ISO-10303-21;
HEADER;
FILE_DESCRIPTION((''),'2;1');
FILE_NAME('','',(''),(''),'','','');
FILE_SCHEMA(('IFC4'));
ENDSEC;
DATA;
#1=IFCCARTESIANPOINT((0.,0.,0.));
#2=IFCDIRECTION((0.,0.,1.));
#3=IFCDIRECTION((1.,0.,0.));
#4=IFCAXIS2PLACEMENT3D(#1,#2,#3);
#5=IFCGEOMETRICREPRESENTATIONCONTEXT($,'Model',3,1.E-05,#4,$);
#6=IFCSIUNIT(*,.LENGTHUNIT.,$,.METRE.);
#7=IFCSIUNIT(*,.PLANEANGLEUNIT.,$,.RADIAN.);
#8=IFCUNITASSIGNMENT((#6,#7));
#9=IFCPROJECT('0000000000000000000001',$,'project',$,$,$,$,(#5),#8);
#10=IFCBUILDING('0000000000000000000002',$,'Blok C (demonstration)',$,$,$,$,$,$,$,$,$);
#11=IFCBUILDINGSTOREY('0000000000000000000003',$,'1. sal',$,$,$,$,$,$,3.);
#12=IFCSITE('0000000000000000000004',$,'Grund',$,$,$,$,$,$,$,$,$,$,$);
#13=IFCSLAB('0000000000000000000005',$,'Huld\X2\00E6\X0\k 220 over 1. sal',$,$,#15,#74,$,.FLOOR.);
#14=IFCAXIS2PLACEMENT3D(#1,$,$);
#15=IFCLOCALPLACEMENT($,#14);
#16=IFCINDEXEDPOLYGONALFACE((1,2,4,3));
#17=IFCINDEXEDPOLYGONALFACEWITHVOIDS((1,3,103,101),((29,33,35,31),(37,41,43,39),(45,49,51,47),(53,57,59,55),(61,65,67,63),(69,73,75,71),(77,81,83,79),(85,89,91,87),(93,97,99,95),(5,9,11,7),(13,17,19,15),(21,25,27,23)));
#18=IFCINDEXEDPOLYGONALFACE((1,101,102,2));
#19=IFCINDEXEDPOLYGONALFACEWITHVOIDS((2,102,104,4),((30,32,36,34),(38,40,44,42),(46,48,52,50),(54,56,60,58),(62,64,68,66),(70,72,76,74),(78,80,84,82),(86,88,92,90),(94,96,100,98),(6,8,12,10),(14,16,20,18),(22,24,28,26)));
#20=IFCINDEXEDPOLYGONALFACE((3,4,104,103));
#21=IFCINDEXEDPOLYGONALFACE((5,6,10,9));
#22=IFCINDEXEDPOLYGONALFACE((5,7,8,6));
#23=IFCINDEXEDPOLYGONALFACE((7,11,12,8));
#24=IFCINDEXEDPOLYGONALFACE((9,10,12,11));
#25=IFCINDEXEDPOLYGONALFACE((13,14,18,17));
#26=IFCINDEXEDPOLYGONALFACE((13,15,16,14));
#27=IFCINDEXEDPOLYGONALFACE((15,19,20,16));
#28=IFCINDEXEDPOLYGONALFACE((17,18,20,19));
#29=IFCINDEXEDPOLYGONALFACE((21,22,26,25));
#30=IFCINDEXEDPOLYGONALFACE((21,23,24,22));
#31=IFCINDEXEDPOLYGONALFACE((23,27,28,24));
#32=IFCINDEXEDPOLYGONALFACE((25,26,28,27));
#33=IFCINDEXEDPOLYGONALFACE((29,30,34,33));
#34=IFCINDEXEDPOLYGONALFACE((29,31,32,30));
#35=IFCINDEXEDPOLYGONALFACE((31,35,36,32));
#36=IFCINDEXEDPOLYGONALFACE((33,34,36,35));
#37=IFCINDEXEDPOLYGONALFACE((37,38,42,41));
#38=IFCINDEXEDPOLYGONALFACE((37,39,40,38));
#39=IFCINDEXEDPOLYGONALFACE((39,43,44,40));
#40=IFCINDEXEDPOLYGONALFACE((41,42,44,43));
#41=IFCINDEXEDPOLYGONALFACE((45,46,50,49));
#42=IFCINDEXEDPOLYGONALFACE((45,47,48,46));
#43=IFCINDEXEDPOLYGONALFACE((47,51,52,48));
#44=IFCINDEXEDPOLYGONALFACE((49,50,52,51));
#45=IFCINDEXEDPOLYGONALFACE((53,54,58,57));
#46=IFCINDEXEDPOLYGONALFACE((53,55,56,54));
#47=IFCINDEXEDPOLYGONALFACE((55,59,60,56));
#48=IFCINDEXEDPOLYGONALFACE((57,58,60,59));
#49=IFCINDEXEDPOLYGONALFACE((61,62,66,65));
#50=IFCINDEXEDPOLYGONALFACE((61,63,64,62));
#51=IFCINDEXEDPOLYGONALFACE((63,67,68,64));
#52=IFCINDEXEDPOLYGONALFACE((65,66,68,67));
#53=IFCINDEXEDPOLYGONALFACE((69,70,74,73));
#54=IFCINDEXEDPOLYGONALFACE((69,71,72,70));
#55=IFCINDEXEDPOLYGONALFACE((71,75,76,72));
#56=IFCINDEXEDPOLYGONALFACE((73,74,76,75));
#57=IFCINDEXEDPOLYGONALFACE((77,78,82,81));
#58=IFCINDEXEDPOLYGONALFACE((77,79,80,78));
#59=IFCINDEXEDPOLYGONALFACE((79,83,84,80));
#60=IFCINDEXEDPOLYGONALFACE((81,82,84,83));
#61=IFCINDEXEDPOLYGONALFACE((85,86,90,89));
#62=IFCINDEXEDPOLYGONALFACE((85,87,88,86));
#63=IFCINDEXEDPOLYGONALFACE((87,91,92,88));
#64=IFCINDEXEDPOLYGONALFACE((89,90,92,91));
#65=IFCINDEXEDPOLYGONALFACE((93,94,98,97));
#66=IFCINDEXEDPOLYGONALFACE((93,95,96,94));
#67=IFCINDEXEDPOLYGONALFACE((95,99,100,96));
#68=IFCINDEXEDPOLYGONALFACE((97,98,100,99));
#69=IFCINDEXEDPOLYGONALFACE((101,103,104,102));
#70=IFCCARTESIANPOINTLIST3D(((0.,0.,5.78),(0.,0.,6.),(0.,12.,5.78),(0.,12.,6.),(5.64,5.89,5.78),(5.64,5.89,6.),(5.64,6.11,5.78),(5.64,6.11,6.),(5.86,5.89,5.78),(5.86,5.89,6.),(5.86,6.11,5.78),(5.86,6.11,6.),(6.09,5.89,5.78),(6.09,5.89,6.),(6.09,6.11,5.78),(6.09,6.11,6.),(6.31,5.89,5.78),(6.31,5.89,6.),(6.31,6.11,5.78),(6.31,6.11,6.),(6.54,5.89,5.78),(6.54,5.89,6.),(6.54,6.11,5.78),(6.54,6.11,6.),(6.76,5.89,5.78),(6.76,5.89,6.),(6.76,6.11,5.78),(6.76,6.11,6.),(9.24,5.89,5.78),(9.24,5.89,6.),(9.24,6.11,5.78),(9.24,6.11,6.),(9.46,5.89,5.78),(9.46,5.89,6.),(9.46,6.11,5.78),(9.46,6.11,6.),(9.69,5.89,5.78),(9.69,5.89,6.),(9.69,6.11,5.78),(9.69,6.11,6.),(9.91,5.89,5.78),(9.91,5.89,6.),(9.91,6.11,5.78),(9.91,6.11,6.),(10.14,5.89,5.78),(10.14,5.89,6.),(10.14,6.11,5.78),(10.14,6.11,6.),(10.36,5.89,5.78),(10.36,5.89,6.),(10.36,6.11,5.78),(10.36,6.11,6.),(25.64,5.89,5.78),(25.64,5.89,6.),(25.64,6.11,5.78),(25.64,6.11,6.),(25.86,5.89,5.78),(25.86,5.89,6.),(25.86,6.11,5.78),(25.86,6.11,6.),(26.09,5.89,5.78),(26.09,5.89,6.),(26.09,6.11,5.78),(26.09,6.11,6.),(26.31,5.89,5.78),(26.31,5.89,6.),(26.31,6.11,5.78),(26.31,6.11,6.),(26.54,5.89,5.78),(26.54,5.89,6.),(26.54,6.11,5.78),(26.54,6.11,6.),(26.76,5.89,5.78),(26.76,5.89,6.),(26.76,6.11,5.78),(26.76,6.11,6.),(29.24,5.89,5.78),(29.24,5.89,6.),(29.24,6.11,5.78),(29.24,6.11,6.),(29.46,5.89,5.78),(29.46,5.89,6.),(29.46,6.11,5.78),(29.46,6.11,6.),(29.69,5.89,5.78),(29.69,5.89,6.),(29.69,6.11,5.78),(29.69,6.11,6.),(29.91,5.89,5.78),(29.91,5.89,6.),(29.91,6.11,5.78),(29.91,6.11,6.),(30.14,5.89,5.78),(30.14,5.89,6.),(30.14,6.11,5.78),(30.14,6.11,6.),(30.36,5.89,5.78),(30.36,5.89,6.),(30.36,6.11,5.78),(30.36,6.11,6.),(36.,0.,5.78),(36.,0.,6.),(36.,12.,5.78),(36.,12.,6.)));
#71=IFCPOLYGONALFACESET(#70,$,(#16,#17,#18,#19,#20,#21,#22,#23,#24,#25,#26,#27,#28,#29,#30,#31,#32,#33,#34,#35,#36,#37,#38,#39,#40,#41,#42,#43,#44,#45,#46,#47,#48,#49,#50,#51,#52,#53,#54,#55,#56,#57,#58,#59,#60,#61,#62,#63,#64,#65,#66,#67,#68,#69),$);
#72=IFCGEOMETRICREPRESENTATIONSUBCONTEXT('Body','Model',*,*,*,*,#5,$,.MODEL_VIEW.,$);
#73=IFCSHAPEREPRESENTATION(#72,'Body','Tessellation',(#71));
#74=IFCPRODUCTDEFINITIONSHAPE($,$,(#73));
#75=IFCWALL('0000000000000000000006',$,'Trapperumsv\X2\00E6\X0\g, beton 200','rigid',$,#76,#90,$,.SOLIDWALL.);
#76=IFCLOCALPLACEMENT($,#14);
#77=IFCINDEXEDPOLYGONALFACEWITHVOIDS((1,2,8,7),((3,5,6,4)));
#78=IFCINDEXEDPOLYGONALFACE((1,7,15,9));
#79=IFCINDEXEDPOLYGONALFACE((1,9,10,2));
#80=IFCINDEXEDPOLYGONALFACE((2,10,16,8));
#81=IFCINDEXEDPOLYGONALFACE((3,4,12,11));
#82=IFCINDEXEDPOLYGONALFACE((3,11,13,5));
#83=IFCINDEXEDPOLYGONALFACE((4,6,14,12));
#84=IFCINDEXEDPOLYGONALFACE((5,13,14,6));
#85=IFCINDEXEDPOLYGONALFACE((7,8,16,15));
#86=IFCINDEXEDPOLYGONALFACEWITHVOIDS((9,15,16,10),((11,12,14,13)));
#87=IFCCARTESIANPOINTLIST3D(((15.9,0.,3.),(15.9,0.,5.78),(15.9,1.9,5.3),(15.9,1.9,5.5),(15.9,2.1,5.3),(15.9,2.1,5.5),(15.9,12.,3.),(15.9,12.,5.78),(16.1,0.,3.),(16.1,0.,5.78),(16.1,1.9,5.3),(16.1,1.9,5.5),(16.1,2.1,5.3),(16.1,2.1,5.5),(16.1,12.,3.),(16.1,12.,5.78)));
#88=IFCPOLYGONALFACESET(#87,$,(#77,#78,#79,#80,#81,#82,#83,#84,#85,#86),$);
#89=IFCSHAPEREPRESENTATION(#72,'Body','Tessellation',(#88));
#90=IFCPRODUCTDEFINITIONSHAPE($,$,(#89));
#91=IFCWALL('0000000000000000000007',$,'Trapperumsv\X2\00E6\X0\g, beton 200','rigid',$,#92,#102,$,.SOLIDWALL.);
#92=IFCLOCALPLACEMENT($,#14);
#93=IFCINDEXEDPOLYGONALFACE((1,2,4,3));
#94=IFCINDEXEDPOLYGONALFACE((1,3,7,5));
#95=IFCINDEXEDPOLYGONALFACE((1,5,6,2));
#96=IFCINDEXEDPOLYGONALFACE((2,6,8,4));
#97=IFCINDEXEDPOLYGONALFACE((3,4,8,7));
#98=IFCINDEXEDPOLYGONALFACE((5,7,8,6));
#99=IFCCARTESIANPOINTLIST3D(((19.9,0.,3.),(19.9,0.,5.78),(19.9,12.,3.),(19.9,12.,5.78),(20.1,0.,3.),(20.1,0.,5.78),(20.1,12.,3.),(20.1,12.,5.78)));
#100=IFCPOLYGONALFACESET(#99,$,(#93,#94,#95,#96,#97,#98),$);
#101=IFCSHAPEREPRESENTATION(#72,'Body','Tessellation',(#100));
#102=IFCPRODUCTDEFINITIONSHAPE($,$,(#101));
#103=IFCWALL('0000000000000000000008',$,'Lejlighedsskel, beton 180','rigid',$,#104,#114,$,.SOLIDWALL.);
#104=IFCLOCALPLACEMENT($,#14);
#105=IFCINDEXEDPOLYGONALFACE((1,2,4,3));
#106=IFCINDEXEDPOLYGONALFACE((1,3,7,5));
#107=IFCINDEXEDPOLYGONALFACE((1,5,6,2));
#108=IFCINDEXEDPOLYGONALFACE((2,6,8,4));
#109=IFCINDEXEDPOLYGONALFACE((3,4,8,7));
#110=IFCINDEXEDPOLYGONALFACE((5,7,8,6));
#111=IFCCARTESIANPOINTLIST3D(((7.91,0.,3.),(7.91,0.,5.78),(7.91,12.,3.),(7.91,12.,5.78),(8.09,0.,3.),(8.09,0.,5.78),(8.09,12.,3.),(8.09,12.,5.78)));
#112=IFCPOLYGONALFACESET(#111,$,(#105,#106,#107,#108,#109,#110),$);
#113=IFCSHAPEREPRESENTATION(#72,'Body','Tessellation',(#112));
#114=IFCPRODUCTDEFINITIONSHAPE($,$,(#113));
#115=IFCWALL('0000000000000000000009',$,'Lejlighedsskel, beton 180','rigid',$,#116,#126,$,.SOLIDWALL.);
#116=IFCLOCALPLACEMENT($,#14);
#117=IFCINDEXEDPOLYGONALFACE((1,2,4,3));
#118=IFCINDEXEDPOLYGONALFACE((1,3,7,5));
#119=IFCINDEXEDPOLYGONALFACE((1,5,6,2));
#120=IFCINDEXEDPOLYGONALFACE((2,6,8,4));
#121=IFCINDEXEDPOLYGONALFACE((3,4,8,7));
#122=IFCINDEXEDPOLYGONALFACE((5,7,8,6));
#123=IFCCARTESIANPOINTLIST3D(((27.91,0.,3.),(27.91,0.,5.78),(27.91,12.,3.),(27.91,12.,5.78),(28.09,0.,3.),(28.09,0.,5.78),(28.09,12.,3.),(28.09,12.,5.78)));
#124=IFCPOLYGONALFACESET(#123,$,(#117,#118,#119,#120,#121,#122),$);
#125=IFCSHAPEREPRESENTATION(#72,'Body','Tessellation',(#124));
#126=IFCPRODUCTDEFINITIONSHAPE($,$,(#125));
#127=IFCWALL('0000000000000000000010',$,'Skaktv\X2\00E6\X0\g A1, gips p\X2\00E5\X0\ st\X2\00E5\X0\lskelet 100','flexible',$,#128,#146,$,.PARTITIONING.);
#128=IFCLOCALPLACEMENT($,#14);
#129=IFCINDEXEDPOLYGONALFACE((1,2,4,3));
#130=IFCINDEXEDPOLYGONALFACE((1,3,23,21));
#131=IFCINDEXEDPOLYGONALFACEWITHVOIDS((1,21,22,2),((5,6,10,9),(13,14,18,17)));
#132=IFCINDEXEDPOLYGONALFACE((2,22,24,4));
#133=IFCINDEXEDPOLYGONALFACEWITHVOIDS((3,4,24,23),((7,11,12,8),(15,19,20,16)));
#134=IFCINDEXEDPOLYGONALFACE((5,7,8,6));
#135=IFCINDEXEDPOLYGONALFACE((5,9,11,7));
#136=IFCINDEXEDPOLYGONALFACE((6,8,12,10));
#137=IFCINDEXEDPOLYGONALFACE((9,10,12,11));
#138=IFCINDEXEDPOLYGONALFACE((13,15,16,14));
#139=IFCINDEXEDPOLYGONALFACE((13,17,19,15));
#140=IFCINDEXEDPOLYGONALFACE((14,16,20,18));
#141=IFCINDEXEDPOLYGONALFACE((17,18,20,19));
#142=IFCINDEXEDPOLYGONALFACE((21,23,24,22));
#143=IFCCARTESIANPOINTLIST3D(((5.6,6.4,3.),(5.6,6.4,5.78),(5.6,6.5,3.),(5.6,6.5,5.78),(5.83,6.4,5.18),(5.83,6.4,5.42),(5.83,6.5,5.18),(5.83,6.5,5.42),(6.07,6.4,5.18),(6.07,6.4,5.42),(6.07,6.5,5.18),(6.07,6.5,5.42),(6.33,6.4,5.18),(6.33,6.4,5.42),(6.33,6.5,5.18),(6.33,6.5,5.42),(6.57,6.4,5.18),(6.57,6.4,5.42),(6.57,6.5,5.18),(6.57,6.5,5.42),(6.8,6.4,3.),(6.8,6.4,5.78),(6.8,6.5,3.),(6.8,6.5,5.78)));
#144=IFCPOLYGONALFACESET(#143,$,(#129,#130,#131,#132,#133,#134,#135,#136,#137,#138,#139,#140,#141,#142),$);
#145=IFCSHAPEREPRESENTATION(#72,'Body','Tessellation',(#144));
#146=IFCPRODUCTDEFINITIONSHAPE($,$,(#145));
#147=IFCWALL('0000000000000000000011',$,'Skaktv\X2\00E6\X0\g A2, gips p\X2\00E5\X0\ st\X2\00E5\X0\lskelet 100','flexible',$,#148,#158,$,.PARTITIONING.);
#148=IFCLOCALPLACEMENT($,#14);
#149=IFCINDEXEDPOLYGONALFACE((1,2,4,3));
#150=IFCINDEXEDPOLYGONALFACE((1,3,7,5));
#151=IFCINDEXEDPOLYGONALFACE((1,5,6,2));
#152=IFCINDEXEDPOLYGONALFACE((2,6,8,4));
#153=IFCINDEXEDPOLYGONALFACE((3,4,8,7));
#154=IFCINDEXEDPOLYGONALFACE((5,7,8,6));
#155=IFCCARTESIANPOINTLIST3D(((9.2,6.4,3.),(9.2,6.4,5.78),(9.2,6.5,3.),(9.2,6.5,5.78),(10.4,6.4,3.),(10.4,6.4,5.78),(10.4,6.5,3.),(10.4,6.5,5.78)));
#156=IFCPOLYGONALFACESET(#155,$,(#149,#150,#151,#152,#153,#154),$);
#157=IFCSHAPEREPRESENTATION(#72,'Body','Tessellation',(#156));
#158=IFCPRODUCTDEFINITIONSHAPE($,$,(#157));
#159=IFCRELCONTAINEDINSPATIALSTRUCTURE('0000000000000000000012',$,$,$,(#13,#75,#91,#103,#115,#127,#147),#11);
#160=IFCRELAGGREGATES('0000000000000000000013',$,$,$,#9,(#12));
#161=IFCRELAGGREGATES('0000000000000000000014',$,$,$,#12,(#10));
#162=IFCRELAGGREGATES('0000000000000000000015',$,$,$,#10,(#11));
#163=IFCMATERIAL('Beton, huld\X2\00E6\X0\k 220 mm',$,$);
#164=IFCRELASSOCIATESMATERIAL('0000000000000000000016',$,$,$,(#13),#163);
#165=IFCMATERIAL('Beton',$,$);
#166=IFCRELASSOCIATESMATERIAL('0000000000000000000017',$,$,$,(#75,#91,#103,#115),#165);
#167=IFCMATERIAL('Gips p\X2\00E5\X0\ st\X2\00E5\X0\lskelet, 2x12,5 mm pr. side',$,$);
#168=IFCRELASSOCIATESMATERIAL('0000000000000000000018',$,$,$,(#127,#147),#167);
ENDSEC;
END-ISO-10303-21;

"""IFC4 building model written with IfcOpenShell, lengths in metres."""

from ifc_helpers import new_model, si_unit, frame, origin_with_axes, place, context, subcontext, project, spatial, polyline, outline, extrude, material, element, save


model = new_model("IFC4")

# Units and contexts
model_context = context("Model", 3, precision=1e-05, world=origin_with_axes())
body_context = subcontext(model_context, "Body", "Model", "MODEL_VIEW")
ifc_project = project(units=[si_unit("LENGTHUNIT", "METRE"), si_unit("PLANEANGLEUNIT", "RADIAN")], contexts=[model_context])

# Site, building, storey
site = spatial("IfcSite", under=ifc_project, Name="Grund")
building = spatial("IfcBuilding", under=site, Name="Blok C (demonstration)")
storey = spatial("IfcBuildingStorey", under=building, Name="1. sal", Elevation=3.0)

# Slab, openings
ifc_material_1 = material(Name="Beton, huldæk 220 mm")
slab_placement = place(None, origin_with_axes())
slab = element("IfcSlab", 1, at=slab_placement, inside=storey, material=ifc_material_1, Name="Huldæk 220 over 1. sal", PredefinedType="FLOOR", context=body_context, shape_type="SweptSolid", body=[
    extrude(outline(polyline([(0.0, 0.0), (36.0, 0.0), (36.0, 12.0), (0.0, 12.0), (0.0, 0.0)])), frame((0.0, 0.0, 5.78)), (0.0, 0.0, 1.0), 0.22),
])
opening_1_placement = place(slab_placement, origin_with_axes())
element("IfcOpeningElement", 2, at=opening_1_placement, cuts=slab, PredefinedType="OPENING", context=body_context, shape_type="SweptSolid", body=[
    extrude(outline(polyline([(5.64, 5.89), (5.86, 5.89), (5.86, 6.11), (5.64, 6.11), (5.64, 5.89)])), frame((0.0, 0.0, 5.77)), (0.0, 0.0, 1.0), 0.24),
])
opening_2_placement = place(slab_placement, origin_with_axes())
element("IfcOpeningElement", 3, at=opening_2_placement, cuts=slab, PredefinedType="OPENING", context=body_context, shape_type="SweptSolid", body=[
    extrude(outline(polyline([(6.09, 5.89), (6.31, 5.89), (6.31, 6.11), (6.09, 6.11), (6.09, 5.89)])), frame((0.0, 0.0, 5.77)), (0.0, 0.0, 1.0), 0.24),
])
opening_3_placement = place(slab_placement, origin_with_axes())
element("IfcOpeningElement", 4, at=opening_3_placement, cuts=slab, PredefinedType="OPENING", context=body_context, shape_type="SweptSolid", body=[
    extrude(outline(polyline([(6.54, 5.89), (6.76, 5.89), (6.76, 6.11), (6.54, 6.11), (6.54, 5.89)])), frame((0.0, 0.0, 5.77)), (0.0, 0.0, 1.0), 0.24),
])
opening_4_placement = place(slab_placement, origin_with_axes())
element("IfcOpeningElement", 5, at=opening_4_placement, cuts=slab, PredefinedType="OPENING", context=body_context, shape_type="SweptSolid", body=[
    extrude(outline(polyline([(9.24, 5.89), (9.46, 5.89), (9.46, 6.11), (9.24, 6.11), (9.24, 5.89)])), frame((0.0, 0.0, 5.77)), (0.0, 0.0, 1.0), 0.24),
])
opening_5_placement = place(slab_placement, origin_with_axes())
element("IfcOpeningElement", 6, at=opening_5_placement, cuts=slab, PredefinedType="OPENING", context=body_context, shape_type="SweptSolid", body=[
    extrude(outline(polyline([(9.69, 5.89), (9.91, 5.89), (9.91, 6.11), (9.69, 6.11), (9.69, 5.89)])), frame((0.0, 0.0, 5.77)), (0.0, 0.0, 1.0), 0.24),
])
opening_6_placement = place(slab_placement, origin_with_axes())
element("IfcOpeningElement", 7, at=opening_6_placement, cuts=slab, PredefinedType="OPENING", context=body_context, shape_type="SweptSolid", body=[
    extrude(outline(polyline([(10.14, 5.89), (10.36, 5.89), (10.36, 6.11), (10.14, 6.11), (10.14, 5.89)])), frame((0.0, 0.0, 5.77)), (0.0, 0.0, 1.0), 0.24),
])
opening_7_placement = place(slab_placement, origin_with_axes())
element("IfcOpeningElement", 8, at=opening_7_placement, cuts=slab, PredefinedType="OPENING", context=body_context, shape_type="SweptSolid", body=[
    extrude(outline(polyline([(25.64, 5.89), (25.86, 5.89), (25.86, 6.11), (25.64, 6.11), (25.64, 5.89)])), frame((0.0, 0.0, 5.77)), (0.0, 0.0, 1.0), 0.24),
])
opening_8_placement = place(slab_placement, origin_with_axes())
element("IfcOpeningElement", 9, at=opening_8_placement, cuts=slab, PredefinedType="OPENING", context=body_context, shape_type="SweptSolid", body=[
    extrude(outline(polyline([(26.09, 5.89), (26.31, 5.89), (26.31, 6.11), (26.09, 6.11), (26.09, 5.89)])), frame((0.0, 0.0, 5.77)), (0.0, 0.0, 1.0), 0.24),
])
opening_9_placement = place(slab_placement, origin_with_axes())
element("IfcOpeningElement", 10, at=opening_9_placement, cuts=slab, PredefinedType="OPENING", context=body_context, shape_type="SweptSolid", body=[
    extrude(outline(polyline([(26.54, 5.89), (26.76, 5.89), (26.76, 6.11), (26.54, 6.11), (26.54, 5.89)])), frame((0.0, 0.0, 5.77)), (0.0, 0.0, 1.0), 0.24),
])
opening_10_placement = place(slab_placement, origin_with_axes())
element("IfcOpeningElement", 11, at=opening_10_placement, cuts=slab, PredefinedType="OPENING", context=body_context, shape_type="SweptSolid", body=[
    extrude(outline(polyline([(29.24, 5.89), (29.46, 5.89), (29.46, 6.11), (29.24, 6.11), (29.24, 5.89)])), frame((0.0, 0.0, 5.77)), (0.0, 0.0, 1.0), 0.24),
])
opening_11_placement = place(slab_placement, origin_with_axes())
element("IfcOpeningElement", 12, at=opening_11_placement, cuts=slab, PredefinedType="OPENING", context=body_context, shape_type="SweptSolid", body=[
    extrude(outline(polyline([(29.69, 5.89), (29.91, 5.89), (29.91, 6.11), (29.69, 6.11), (29.69, 5.89)])), frame((0.0, 0.0, 5.77)), (0.0, 0.0, 1.0), 0.24),
])
opening_12_placement = place(slab_placement, origin_with_axes())
element("IfcOpeningElement", 13, at=opening_12_placement, cuts=slab, PredefinedType="OPENING", context=body_context, shape_type="SweptSolid", body=[
    extrude(outline(polyline([(30.14, 5.89), (30.36, 5.89), (30.36, 6.11), (30.14, 6.11), (30.14, 5.89)])), frame((0.0, 0.0, 5.77)), (0.0, 0.0, 1.0), 0.24),
])

# Wall, opening
ifc_material_2 = material(Name="Beton")
wall_1_placement = place(None, origin_with_axes())
wall_1 = element("IfcWall", 14, at=wall_1_placement, inside=storey, material=ifc_material_2, Name="Trapperumsvæg, beton 200", Description="rigid", PredefinedType="SOLIDWALL", context=body_context, shape_type="SweptSolid", body=[
    extrude(outline(polyline([(15.9, 0.0), (16.1, 0.0), (16.1, 12.0), (15.9, 12.0), (15.9, 0.0)])), frame((0.0, 0.0, 3.0)), (0.0, 0.0, 1.0), 2.78),
])
opening_13_placement = place(wall_1_placement, origin_with_axes())
element("IfcOpeningElement", 15, at=opening_13_placement, cuts=wall_1, PredefinedType="OPENING", context=body_context, shape_type="SweptSolid", body=[
    extrude(outline(polyline([(15.88, 1.9), (16.12, 1.9), (16.12, 2.1), (15.88, 2.1), (15.88, 1.9)])), frame((0.0, 0.0, 5.3)), (0.0, 0.0, 1.0), 0.2),
])

# Walls
wall_2_placement = place(None, origin_with_axes())
element("IfcWall", 16, at=wall_2_placement, inside=storey, material=ifc_material_2, Name="Trapperumsvæg, beton 200", Description="rigid", PredefinedType="SOLIDWALL", context=body_context, shape_type="SweptSolid", body=[
    extrude(outline(polyline([(19.9, 0.0), (20.1, 0.0), (20.1, 12.0), (19.9, 12.0), (19.9, 0.0)])), frame((0.0, 0.0, 3.0)), (0.0, 0.0, 1.0), 2.78),
])
wall_3_placement = place(None, origin_with_axes())
element("IfcWall", 17, at=wall_3_placement, inside=storey, material=ifc_material_2, Name="Lejlighedsskel, beton 180", Description="rigid", PredefinedType="SOLIDWALL", context=body_context, shape_type="SweptSolid", body=[
    extrude(outline(polyline([(7.91, 0.0), (8.09, 0.0), (8.09, 12.0), (7.91, 12.0), (7.91, 0.0)])), frame((0.0, 0.0, 3.0)), (0.0, 0.0, 1.0), 2.78),
])
wall_4_placement = place(None, origin_with_axes())
element("IfcWall", 18, at=wall_4_placement, inside=storey, material=ifc_material_2, Name="Lejlighedsskel, beton 180", Description="rigid", PredefinedType="SOLIDWALL", context=body_context, shape_type="SweptSolid", body=[
    extrude(outline(polyline([(27.91, 0.0), (28.09, 0.0), (28.09, 12.0), (27.91, 12.0), (27.91, 0.0)])), frame((0.0, 0.0, 3.0)), (0.0, 0.0, 1.0), 2.78),
])

# Wall, openings
ifc_material_3 = material(Name="Gips på stålskelet, 2x12,5 mm pr. side")
wall_5_placement = place(None, origin_with_axes())
wall_5 = element("IfcWall", 19, at=wall_5_placement, inside=storey, material=ifc_material_3, Name="Skaktvæg A1, gips på stålskelet 100", Description="flexible", PredefinedType="PARTITIONING", context=body_context, shape_type="SweptSolid", body=[
    extrude(outline(polyline([(5.6, 6.4), (6.8, 6.4), (6.8, 6.5), (5.6, 6.5), (5.6, 6.4)])), frame((0.0, 0.0, 3.0)), (0.0, 0.0, 1.0), 2.78),
])
opening_14_placement = place(wall_5_placement, origin_with_axes())
element("IfcOpeningElement", 20, at=opening_14_placement, cuts=wall_5, PredefinedType="OPENING", context=body_context, shape_type="SweptSolid", body=[
    extrude(outline(polyline([(5.83, 6.33), (6.07, 6.33), (6.07, 6.57), (5.83, 6.57), (5.83, 6.33)])), frame((0.0, 0.0, 5.18)), (0.0, 0.0, 1.0), 0.24),
])
opening_15_placement = place(wall_5_placement, origin_with_axes())
element("IfcOpeningElement", 21, at=opening_15_placement, cuts=wall_5, PredefinedType="OPENING", context=body_context, shape_type="SweptSolid", body=[
    extrude(outline(polyline([(6.33, 6.33), (6.57, 6.33), (6.57, 6.57), (6.33, 6.57), (6.33, 6.33)])), frame((0.0, 0.0, 5.18)), (0.0, 0.0, 1.0), 0.24),
])

# Wall
wall_6_placement = place(None, origin_with_axes())
element("IfcWall", 22, at=wall_6_placement, inside=storey, material=ifc_material_3, Name="Skaktvæg A2, gips på stålskelet 100", Description="flexible", PredefinedType="PARTITIONING", context=body_context, shape_type="SweptSolid", body=[
    extrude(outline(polyline([(9.2, 6.4), (10.4, 6.4), (10.4, 6.5), (9.2, 6.5), (9.2, 6.4)])), frame((0.0, 0.0, 3.0)), (0.0, 0.0, 1.0), 2.78),
])

save(model, "model.ifc")
